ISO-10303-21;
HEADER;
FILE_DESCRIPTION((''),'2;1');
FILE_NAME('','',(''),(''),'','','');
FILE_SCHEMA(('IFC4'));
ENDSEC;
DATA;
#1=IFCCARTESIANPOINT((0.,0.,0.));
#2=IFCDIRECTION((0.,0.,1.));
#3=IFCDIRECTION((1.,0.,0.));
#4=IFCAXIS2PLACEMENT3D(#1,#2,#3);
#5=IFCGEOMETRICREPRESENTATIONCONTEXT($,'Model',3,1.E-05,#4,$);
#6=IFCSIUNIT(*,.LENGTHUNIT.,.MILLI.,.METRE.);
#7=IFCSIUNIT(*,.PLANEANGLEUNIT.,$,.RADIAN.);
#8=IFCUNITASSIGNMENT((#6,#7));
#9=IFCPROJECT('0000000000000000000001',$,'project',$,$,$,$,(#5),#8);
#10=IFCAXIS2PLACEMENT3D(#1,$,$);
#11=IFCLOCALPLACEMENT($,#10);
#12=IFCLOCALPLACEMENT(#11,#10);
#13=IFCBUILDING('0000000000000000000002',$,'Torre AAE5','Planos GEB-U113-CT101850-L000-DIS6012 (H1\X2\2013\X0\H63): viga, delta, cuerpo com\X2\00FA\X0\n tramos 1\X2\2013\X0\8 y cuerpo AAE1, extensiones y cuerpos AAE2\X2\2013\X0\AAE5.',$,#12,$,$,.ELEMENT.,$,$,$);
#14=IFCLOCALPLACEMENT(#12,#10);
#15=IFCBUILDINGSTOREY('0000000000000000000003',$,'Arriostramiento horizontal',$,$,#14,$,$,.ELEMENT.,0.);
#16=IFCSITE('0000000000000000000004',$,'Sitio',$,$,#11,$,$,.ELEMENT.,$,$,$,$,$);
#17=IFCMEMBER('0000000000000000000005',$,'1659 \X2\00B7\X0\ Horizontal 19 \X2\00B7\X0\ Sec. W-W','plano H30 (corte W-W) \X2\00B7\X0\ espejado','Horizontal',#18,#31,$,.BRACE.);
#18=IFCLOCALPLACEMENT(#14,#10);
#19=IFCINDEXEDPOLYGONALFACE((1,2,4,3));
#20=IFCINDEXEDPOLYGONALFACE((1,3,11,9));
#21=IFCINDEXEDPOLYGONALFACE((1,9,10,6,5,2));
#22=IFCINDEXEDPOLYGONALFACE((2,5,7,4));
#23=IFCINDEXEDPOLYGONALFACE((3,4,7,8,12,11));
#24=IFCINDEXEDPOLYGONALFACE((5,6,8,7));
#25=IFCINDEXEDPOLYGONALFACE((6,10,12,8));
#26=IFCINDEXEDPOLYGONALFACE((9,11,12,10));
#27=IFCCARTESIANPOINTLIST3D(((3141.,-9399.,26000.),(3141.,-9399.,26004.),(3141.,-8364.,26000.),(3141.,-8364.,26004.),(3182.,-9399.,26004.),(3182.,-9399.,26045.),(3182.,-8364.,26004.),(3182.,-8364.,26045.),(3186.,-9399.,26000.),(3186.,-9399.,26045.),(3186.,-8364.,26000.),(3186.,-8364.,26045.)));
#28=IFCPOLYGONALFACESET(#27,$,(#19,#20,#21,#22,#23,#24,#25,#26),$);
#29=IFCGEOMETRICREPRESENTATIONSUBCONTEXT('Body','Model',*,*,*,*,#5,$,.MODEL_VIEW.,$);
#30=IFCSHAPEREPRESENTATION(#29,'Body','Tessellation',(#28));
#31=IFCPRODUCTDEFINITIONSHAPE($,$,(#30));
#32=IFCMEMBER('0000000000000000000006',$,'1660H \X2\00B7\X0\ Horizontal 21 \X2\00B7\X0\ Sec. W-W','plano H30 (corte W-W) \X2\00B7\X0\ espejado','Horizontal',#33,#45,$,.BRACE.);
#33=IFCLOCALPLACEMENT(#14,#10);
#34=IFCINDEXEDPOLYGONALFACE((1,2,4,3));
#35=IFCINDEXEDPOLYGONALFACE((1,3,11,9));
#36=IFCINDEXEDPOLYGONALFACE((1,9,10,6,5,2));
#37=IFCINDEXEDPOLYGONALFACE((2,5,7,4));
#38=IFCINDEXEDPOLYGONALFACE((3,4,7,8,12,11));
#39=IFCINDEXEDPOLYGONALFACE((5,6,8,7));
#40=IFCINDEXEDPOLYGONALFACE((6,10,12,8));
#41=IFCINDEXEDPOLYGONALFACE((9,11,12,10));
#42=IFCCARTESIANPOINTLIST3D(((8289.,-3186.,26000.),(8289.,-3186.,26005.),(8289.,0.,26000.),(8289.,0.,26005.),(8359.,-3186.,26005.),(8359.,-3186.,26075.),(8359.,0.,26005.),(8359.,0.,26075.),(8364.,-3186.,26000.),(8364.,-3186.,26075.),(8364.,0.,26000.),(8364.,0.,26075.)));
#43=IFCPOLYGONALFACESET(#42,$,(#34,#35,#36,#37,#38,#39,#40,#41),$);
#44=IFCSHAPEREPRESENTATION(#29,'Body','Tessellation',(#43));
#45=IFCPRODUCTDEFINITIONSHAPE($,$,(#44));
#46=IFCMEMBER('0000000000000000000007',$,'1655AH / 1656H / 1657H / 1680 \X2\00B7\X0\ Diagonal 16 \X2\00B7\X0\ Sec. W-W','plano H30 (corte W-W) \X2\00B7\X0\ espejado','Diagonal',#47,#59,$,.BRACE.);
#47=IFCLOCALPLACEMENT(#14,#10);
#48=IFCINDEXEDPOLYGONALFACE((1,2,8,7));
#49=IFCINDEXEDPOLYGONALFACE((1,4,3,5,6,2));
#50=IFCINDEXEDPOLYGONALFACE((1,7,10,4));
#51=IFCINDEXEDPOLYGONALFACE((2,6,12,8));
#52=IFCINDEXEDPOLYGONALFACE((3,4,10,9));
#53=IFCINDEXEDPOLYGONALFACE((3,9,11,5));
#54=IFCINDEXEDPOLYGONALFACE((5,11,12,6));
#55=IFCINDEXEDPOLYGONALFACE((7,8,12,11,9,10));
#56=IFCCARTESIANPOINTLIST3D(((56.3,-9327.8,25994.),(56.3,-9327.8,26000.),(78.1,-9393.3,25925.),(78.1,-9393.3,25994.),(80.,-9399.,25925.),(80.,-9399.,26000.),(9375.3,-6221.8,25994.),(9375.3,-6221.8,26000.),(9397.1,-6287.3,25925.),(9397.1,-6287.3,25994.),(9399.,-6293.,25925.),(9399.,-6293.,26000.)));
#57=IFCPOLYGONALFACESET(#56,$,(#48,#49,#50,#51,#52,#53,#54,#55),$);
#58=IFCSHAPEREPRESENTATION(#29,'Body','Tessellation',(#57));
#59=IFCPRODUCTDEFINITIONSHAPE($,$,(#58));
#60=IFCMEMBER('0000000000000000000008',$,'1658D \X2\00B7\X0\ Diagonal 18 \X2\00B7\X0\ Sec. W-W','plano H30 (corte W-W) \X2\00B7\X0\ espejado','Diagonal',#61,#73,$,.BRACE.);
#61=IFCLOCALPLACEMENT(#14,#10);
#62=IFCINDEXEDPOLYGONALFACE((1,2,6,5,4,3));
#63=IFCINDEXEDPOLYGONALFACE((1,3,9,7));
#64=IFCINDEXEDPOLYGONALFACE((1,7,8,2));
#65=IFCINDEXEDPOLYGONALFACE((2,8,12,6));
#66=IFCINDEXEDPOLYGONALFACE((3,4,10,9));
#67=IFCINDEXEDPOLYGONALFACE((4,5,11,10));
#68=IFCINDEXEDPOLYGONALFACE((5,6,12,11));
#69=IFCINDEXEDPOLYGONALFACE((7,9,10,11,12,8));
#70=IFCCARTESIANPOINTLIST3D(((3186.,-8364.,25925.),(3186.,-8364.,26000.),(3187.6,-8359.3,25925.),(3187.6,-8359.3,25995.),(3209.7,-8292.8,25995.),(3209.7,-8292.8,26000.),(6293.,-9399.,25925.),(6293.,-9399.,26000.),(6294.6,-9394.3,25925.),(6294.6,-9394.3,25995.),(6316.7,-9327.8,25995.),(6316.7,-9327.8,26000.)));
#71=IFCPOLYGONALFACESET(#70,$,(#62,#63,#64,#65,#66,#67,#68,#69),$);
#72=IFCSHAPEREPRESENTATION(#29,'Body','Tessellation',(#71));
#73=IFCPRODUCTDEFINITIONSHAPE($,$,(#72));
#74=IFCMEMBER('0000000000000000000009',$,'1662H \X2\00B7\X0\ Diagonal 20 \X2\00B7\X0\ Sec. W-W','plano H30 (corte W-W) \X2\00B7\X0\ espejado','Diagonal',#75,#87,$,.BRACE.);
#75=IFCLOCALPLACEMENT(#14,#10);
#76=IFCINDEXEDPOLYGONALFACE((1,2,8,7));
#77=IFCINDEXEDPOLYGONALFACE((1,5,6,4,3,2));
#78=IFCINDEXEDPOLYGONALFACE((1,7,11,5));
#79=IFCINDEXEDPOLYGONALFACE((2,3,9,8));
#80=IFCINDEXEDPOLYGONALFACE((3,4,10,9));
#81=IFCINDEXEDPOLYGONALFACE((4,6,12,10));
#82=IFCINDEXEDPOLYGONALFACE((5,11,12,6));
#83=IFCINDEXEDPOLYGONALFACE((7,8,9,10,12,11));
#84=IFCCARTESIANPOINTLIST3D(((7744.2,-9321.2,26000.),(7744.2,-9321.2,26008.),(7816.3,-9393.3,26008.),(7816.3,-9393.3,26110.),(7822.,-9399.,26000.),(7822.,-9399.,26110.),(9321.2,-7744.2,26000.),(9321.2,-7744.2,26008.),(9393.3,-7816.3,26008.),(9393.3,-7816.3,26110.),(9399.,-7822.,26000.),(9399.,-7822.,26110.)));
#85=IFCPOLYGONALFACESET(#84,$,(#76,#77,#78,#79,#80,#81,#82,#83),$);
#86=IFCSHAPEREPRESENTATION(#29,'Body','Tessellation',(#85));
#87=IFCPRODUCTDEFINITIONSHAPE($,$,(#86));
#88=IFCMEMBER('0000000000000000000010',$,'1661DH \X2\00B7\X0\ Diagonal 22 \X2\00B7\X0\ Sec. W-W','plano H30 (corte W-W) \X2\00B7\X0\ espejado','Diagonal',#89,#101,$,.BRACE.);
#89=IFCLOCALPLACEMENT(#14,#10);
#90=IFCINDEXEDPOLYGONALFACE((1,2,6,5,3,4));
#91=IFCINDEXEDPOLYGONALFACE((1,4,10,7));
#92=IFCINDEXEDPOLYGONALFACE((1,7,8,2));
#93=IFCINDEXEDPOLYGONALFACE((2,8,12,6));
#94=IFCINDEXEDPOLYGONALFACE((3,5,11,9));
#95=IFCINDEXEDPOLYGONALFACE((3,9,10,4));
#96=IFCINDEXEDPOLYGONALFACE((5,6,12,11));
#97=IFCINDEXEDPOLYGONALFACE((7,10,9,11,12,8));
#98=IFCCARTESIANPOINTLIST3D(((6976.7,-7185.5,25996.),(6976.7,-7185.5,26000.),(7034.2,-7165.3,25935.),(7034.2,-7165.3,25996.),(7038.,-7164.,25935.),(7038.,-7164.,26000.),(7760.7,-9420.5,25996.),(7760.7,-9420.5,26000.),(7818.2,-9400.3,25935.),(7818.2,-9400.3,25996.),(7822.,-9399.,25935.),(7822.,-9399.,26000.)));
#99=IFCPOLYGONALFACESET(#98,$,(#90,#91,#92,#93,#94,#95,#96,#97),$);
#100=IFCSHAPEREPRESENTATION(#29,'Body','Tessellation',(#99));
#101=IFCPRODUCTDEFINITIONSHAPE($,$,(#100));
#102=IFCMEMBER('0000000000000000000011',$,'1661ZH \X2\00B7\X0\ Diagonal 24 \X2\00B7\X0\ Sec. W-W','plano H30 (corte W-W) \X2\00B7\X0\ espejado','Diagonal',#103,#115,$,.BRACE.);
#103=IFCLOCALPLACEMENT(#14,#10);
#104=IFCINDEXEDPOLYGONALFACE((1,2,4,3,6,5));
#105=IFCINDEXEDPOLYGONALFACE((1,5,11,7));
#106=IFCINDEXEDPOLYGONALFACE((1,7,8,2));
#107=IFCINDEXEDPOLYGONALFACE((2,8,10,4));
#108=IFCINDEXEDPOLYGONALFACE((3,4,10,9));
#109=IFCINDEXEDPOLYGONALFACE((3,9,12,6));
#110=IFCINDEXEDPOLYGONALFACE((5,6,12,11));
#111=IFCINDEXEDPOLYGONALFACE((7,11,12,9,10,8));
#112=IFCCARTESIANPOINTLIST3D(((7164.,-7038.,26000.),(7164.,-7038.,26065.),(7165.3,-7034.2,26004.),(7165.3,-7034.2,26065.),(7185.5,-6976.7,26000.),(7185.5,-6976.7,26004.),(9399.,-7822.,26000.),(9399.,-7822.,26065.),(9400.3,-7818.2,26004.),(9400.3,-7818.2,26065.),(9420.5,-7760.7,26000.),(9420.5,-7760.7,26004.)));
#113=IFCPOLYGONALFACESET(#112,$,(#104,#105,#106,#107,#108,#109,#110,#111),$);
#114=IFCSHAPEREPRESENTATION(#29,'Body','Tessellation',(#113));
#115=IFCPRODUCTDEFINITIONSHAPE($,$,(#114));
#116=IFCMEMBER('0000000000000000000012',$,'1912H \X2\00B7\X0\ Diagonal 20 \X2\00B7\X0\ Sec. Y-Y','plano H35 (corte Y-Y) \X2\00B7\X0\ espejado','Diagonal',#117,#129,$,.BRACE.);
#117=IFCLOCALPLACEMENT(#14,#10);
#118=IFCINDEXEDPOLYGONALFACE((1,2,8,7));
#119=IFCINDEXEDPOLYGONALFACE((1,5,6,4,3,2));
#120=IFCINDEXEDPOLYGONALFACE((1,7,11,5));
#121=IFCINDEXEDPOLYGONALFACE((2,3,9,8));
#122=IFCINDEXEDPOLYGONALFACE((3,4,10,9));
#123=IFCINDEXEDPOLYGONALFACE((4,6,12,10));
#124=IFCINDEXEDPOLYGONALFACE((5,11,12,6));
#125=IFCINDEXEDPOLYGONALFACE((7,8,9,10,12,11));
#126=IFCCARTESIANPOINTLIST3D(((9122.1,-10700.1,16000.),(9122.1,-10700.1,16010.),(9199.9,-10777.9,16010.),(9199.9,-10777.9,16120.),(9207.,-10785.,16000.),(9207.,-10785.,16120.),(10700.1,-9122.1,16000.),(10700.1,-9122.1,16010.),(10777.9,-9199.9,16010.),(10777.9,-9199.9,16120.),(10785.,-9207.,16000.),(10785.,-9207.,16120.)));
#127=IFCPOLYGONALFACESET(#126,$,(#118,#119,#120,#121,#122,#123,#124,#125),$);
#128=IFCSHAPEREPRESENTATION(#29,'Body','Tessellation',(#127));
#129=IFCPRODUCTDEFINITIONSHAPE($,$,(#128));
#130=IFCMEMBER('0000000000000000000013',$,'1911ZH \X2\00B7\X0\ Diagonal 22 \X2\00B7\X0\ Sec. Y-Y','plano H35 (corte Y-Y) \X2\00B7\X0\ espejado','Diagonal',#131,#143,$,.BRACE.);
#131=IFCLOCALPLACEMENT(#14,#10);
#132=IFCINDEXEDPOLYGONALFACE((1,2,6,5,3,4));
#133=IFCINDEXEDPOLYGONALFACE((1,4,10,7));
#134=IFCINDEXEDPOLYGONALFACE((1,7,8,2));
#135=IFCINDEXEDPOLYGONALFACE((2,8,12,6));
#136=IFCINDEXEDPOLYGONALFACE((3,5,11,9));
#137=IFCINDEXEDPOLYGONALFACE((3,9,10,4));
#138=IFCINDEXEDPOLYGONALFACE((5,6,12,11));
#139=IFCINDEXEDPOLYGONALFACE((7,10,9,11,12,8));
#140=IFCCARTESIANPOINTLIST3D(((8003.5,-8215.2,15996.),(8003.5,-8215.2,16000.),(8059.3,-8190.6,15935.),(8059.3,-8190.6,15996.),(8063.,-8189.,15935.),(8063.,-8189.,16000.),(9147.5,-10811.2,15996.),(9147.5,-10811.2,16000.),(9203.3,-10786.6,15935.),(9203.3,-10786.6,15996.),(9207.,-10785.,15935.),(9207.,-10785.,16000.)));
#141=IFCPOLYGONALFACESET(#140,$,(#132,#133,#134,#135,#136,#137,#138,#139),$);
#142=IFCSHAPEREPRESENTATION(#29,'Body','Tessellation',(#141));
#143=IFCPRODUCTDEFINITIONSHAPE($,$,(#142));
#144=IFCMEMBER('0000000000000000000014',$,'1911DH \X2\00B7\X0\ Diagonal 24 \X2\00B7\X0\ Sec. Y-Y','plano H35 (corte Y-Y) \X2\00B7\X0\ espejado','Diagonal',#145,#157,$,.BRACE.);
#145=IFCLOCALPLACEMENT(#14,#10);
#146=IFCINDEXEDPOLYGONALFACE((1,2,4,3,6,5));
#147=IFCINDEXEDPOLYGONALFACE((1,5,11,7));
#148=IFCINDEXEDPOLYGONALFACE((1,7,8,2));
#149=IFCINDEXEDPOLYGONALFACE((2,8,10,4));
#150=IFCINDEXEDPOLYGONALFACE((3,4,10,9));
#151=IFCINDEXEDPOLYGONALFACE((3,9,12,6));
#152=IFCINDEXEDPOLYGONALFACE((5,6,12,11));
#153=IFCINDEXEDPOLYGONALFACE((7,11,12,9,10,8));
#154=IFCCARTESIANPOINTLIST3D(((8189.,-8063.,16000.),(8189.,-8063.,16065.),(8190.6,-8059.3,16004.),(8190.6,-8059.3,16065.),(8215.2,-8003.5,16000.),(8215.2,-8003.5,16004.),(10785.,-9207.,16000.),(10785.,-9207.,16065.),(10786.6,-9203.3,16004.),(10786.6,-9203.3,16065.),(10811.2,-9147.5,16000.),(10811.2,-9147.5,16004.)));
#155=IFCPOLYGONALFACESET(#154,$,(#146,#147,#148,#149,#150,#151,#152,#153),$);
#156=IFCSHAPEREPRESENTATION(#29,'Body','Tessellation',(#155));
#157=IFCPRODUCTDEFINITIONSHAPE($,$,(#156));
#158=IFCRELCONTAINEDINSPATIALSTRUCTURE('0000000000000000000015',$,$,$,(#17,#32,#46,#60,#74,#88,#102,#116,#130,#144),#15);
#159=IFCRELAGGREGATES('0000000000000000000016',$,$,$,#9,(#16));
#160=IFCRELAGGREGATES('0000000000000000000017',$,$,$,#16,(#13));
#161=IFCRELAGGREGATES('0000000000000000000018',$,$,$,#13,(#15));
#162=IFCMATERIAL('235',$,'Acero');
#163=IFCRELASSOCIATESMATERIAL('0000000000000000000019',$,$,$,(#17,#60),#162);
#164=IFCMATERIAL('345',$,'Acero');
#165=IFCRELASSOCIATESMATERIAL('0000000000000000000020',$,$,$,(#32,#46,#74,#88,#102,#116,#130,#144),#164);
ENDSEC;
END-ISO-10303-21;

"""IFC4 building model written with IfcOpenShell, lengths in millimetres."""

from ifc_helpers import new_model, si_unit, frame, frame_2d, origin, origin_with_axes, place, context, subcontext, project, spatial, l_section, extrude, material, element, save


model = new_model("IFC4")

# Units and contexts
model_context = context("Model", 3, precision=1e-05, world=origin_with_axes())
body_context = subcontext(model_context, "Body", "Model", "MODEL_VIEW")
ifc_project = project(units=[si_unit("LENGTHUNIT", "METRE", prefix="MILLI"), si_unit("PLANEANGLEUNIT", "RADIAN")], contexts=[model_context])

# Site, building, storey
site_placement = place(None, origin())
site = spatial("IfcSite", under=ifc_project, at=site_placement, Name="Sitio", CompositionType="ELEMENT")
building_placement = place(site_placement, origin())
building = spatial("IfcBuilding", under=site, at=building_placement, Name="Torre AAE5", Description="Planos GEB-U113-CT101850-L000-DIS6012 (H1–H63): viga, delta, cuerpo común tramos 1–8 y cuerpo AAE1, extensiones y cuerpos AAE2–AAE5.", CompositionType="ELEMENT")
storey_placement = place(building_placement, origin())
storey = spatial("IfcBuildingStorey", under=building, at=storey_placement, Name="Arriostramiento horizontal", CompositionType="ELEMENT", Elevation=0.0)

# Members
ifc_material_1 = material(Name="235", Category="Acero")
ifc_material_2 = material(Name="345", Category="Acero")
for number, where, z_axis, x_axis, name in (
    (1, (3186.0, -9399.0, 26000.0), (0.0, 1.0, 0.0), (-1.0, 0.0, 0.0), "1659 · Horizontal 19 · Sec. W-W"),
):
    element("IfcMember", number, at=place(storey_placement, frame(where, z_axis=z_axis, x_axis=x_axis)), inside=storey, material=ifc_material_1, Name=name, Description="plano H30 (corte W-W) · espejado", ObjectType="Horizontal", PredefinedType="BRACE", context=body_context, shape_type="SweptSolid", body=[
        extrude(l_section(Depth=45.0, Width=45.0, Thickness=4.0, at=frame_2d((22.5, 22.5))), None, (0.0, 0.0, 1.0), 1035.0),
    ])
member_1_placement = place(storey_placement, frame((8364.0, -3186.0, 26000.0), z_axis=(0.0, 1.0, 0.0), x_axis=(-1.0, 0.0, 0.0)))
element("IfcMember", 2, at=member_1_placement, inside=storey, material=ifc_material_2, Name="1660H · Horizontal 21 · Sec. W-W", Description="plano H30 (corte W-W) · espejado", ObjectType="Horizontal", PredefinedType="BRACE", context=body_context, shape_type="SweptSolid", body=[
    extrude(l_section(Depth=75.0, Width=75.0, Thickness=5.0, at=frame_2d((37.5, 37.5))), None, (0.0, 0.0, 1.0), 3186.0),
])
member_2_placement = place(storey_placement, frame((9399.0, -6293.0, 26000.0), z_axis=(-0.948693, -0.316197, 0.0), x_axis=(-0.316197, 0.948693, 0.0)))
element("IfcMember", 3, at=member_2_placement, inside=storey, material=ifc_material_2, Name="1655AH / 1656H / 1657H / 1680 · Diagonal 16 · Sec. W-W", Description="plano H30 (corte W-W) · espejado", ObjectType="Diagonal", PredefinedType="BRACE", context=body_context, shape_type="SweptSolid", body=[
    extrude(l_section(Depth=75.0, Width=75.0, Thickness=6.0, at=frame_2d((37.5, 37.5))), None, (0.0, 0.0, 1.0), 9823.0),
])
member_3_placement = place(storey_placement, frame((6293.0, -9399.0, 26000.0), z_axis=(-0.948744, 0.316045, 0.0), x_axis=(0.316045, 0.948744, 0.0)))
element("IfcMember", 4, at=member_3_placement, inside=storey, material=ifc_material_1, Name="1658D · Diagonal 18 · Sec. W-W", Description="plano H30 (corte W-W) · espejado", ObjectType="Diagonal", PredefinedType="BRACE", context=body_context, shape_type="SweptSolid", body=[
    extrude(l_section(Depth=75.0, Width=75.0, Thickness=5.0, at=frame_2d((37.5, 37.5))), None, (0.0, 0.0, 1.0), 3274.9),
])
member_4_placement = place(storey_placement, frame((7822.0, -9399.0, 26000.0), z_axis=(0.707107, 0.707107, 0.0), x_axis=(-0.707107, 0.707107, 0.0)))
element("IfcMember", 5, at=member_4_placement, inside=storey, material=ifc_material_2, Name="1662H · Diagonal 20 · Sec. W-W", Description="plano H30 (corte W-W) · espejado", ObjectType="Diagonal", PredefinedType="BRACE", context=body_context, shape_type="SweptSolid", body=[
    extrude(l_section(Depth=110.0, Width=110.0, Thickness=8.0, at=frame_2d((55.0, 55.0))), None, (0.0, 0.0, 1.0), 2230.2),
])
for number, where, z_axis, x_axis, name in (
    (6, (7038.0, -7164.0, 26000.0), (0.331009, -0.943628, 0.0), (-0.943628, -0.331009, 0.0), "1661DH · Diagonal 22 · Sec. W-W"),
    (7, (7164.0, -7038.0, 26000.0), (0.943628, -0.331009, 0.0), (0.331009, 0.943628, 0.0), "1661ZH · Diagonal 24 · Sec. W-W"),
):
    element("IfcMember", number, at=place(storey_placement, frame(where, z_axis=z_axis, x_axis=x_axis)), inside=storey, material=ifc_material_2, Name=name, Description="plano H30 (corte W-W) · espejado", ObjectType="Diagonal", PredefinedType="BRACE", context=body_context, shape_type="SweptSolid", body=[
        extrude(l_section(Depth=65.0, Width=65.0, Thickness=4.0, at=frame_2d((32.5, 32.5))), None, (0.0, 0.0, 1.0), 2368.5),
    ])
member_5_placement = place(storey_placement, frame((9207.0, -10785.0, 16000.0), z_axis=(0.707107, 0.707107, 0.0), x_axis=(-0.707107, 0.707107, 0.0)))
element("IfcMember", 8, at=member_5_placement, inside=storey, material=ifc_material_2, Name="1912H · Diagonal 20 · Sec. Y-Y", Description="plano H35 (corte Y-Y) · espejado", ObjectType="Diagonal", PredefinedType="BRACE", context=body_context, shape_type="SweptSolid", body=[
    extrude(l_section(Depth=120.0, Width=120.0, Thickness=10.0, at=frame_2d((60.0, 60.0))), None, (0.0, 0.0, 1.0), 2231.6),
])
for number, where, z_axis, x_axis, name in (
    (9, (8063.0, -8189.0, 16000.0), (0.403258, -0.915086, 0.0), (-0.915086, -0.403258, 0.0), "1911ZH · Diagonal 22 · Sec. Y-Y"),
    (10, (8189.0, -8063.0, 16000.0), (0.915086, -0.403258, 0.0), (0.403258, 0.915086, 0.0), "1911DH · Diagonal 24 · Sec. Y-Y"),
):
    element("IfcMember", number, at=place(storey_placement, frame(where, z_axis=z_axis, x_axis=x_axis)), inside=storey, material=ifc_material_2, Name=name, Description="plano H35 (corte Y-Y) · espejado", ObjectType="Diagonal", PredefinedType="BRACE", context=body_context, shape_type="SweptSolid", body=[
        extrude(l_section(Depth=65.0, Width=65.0, Thickness=4.0, at=frame_2d((32.5, 32.5))), None, (0.0, 0.0, 1.0), 2836.9),
    ])

save(model, "model.ifc")
